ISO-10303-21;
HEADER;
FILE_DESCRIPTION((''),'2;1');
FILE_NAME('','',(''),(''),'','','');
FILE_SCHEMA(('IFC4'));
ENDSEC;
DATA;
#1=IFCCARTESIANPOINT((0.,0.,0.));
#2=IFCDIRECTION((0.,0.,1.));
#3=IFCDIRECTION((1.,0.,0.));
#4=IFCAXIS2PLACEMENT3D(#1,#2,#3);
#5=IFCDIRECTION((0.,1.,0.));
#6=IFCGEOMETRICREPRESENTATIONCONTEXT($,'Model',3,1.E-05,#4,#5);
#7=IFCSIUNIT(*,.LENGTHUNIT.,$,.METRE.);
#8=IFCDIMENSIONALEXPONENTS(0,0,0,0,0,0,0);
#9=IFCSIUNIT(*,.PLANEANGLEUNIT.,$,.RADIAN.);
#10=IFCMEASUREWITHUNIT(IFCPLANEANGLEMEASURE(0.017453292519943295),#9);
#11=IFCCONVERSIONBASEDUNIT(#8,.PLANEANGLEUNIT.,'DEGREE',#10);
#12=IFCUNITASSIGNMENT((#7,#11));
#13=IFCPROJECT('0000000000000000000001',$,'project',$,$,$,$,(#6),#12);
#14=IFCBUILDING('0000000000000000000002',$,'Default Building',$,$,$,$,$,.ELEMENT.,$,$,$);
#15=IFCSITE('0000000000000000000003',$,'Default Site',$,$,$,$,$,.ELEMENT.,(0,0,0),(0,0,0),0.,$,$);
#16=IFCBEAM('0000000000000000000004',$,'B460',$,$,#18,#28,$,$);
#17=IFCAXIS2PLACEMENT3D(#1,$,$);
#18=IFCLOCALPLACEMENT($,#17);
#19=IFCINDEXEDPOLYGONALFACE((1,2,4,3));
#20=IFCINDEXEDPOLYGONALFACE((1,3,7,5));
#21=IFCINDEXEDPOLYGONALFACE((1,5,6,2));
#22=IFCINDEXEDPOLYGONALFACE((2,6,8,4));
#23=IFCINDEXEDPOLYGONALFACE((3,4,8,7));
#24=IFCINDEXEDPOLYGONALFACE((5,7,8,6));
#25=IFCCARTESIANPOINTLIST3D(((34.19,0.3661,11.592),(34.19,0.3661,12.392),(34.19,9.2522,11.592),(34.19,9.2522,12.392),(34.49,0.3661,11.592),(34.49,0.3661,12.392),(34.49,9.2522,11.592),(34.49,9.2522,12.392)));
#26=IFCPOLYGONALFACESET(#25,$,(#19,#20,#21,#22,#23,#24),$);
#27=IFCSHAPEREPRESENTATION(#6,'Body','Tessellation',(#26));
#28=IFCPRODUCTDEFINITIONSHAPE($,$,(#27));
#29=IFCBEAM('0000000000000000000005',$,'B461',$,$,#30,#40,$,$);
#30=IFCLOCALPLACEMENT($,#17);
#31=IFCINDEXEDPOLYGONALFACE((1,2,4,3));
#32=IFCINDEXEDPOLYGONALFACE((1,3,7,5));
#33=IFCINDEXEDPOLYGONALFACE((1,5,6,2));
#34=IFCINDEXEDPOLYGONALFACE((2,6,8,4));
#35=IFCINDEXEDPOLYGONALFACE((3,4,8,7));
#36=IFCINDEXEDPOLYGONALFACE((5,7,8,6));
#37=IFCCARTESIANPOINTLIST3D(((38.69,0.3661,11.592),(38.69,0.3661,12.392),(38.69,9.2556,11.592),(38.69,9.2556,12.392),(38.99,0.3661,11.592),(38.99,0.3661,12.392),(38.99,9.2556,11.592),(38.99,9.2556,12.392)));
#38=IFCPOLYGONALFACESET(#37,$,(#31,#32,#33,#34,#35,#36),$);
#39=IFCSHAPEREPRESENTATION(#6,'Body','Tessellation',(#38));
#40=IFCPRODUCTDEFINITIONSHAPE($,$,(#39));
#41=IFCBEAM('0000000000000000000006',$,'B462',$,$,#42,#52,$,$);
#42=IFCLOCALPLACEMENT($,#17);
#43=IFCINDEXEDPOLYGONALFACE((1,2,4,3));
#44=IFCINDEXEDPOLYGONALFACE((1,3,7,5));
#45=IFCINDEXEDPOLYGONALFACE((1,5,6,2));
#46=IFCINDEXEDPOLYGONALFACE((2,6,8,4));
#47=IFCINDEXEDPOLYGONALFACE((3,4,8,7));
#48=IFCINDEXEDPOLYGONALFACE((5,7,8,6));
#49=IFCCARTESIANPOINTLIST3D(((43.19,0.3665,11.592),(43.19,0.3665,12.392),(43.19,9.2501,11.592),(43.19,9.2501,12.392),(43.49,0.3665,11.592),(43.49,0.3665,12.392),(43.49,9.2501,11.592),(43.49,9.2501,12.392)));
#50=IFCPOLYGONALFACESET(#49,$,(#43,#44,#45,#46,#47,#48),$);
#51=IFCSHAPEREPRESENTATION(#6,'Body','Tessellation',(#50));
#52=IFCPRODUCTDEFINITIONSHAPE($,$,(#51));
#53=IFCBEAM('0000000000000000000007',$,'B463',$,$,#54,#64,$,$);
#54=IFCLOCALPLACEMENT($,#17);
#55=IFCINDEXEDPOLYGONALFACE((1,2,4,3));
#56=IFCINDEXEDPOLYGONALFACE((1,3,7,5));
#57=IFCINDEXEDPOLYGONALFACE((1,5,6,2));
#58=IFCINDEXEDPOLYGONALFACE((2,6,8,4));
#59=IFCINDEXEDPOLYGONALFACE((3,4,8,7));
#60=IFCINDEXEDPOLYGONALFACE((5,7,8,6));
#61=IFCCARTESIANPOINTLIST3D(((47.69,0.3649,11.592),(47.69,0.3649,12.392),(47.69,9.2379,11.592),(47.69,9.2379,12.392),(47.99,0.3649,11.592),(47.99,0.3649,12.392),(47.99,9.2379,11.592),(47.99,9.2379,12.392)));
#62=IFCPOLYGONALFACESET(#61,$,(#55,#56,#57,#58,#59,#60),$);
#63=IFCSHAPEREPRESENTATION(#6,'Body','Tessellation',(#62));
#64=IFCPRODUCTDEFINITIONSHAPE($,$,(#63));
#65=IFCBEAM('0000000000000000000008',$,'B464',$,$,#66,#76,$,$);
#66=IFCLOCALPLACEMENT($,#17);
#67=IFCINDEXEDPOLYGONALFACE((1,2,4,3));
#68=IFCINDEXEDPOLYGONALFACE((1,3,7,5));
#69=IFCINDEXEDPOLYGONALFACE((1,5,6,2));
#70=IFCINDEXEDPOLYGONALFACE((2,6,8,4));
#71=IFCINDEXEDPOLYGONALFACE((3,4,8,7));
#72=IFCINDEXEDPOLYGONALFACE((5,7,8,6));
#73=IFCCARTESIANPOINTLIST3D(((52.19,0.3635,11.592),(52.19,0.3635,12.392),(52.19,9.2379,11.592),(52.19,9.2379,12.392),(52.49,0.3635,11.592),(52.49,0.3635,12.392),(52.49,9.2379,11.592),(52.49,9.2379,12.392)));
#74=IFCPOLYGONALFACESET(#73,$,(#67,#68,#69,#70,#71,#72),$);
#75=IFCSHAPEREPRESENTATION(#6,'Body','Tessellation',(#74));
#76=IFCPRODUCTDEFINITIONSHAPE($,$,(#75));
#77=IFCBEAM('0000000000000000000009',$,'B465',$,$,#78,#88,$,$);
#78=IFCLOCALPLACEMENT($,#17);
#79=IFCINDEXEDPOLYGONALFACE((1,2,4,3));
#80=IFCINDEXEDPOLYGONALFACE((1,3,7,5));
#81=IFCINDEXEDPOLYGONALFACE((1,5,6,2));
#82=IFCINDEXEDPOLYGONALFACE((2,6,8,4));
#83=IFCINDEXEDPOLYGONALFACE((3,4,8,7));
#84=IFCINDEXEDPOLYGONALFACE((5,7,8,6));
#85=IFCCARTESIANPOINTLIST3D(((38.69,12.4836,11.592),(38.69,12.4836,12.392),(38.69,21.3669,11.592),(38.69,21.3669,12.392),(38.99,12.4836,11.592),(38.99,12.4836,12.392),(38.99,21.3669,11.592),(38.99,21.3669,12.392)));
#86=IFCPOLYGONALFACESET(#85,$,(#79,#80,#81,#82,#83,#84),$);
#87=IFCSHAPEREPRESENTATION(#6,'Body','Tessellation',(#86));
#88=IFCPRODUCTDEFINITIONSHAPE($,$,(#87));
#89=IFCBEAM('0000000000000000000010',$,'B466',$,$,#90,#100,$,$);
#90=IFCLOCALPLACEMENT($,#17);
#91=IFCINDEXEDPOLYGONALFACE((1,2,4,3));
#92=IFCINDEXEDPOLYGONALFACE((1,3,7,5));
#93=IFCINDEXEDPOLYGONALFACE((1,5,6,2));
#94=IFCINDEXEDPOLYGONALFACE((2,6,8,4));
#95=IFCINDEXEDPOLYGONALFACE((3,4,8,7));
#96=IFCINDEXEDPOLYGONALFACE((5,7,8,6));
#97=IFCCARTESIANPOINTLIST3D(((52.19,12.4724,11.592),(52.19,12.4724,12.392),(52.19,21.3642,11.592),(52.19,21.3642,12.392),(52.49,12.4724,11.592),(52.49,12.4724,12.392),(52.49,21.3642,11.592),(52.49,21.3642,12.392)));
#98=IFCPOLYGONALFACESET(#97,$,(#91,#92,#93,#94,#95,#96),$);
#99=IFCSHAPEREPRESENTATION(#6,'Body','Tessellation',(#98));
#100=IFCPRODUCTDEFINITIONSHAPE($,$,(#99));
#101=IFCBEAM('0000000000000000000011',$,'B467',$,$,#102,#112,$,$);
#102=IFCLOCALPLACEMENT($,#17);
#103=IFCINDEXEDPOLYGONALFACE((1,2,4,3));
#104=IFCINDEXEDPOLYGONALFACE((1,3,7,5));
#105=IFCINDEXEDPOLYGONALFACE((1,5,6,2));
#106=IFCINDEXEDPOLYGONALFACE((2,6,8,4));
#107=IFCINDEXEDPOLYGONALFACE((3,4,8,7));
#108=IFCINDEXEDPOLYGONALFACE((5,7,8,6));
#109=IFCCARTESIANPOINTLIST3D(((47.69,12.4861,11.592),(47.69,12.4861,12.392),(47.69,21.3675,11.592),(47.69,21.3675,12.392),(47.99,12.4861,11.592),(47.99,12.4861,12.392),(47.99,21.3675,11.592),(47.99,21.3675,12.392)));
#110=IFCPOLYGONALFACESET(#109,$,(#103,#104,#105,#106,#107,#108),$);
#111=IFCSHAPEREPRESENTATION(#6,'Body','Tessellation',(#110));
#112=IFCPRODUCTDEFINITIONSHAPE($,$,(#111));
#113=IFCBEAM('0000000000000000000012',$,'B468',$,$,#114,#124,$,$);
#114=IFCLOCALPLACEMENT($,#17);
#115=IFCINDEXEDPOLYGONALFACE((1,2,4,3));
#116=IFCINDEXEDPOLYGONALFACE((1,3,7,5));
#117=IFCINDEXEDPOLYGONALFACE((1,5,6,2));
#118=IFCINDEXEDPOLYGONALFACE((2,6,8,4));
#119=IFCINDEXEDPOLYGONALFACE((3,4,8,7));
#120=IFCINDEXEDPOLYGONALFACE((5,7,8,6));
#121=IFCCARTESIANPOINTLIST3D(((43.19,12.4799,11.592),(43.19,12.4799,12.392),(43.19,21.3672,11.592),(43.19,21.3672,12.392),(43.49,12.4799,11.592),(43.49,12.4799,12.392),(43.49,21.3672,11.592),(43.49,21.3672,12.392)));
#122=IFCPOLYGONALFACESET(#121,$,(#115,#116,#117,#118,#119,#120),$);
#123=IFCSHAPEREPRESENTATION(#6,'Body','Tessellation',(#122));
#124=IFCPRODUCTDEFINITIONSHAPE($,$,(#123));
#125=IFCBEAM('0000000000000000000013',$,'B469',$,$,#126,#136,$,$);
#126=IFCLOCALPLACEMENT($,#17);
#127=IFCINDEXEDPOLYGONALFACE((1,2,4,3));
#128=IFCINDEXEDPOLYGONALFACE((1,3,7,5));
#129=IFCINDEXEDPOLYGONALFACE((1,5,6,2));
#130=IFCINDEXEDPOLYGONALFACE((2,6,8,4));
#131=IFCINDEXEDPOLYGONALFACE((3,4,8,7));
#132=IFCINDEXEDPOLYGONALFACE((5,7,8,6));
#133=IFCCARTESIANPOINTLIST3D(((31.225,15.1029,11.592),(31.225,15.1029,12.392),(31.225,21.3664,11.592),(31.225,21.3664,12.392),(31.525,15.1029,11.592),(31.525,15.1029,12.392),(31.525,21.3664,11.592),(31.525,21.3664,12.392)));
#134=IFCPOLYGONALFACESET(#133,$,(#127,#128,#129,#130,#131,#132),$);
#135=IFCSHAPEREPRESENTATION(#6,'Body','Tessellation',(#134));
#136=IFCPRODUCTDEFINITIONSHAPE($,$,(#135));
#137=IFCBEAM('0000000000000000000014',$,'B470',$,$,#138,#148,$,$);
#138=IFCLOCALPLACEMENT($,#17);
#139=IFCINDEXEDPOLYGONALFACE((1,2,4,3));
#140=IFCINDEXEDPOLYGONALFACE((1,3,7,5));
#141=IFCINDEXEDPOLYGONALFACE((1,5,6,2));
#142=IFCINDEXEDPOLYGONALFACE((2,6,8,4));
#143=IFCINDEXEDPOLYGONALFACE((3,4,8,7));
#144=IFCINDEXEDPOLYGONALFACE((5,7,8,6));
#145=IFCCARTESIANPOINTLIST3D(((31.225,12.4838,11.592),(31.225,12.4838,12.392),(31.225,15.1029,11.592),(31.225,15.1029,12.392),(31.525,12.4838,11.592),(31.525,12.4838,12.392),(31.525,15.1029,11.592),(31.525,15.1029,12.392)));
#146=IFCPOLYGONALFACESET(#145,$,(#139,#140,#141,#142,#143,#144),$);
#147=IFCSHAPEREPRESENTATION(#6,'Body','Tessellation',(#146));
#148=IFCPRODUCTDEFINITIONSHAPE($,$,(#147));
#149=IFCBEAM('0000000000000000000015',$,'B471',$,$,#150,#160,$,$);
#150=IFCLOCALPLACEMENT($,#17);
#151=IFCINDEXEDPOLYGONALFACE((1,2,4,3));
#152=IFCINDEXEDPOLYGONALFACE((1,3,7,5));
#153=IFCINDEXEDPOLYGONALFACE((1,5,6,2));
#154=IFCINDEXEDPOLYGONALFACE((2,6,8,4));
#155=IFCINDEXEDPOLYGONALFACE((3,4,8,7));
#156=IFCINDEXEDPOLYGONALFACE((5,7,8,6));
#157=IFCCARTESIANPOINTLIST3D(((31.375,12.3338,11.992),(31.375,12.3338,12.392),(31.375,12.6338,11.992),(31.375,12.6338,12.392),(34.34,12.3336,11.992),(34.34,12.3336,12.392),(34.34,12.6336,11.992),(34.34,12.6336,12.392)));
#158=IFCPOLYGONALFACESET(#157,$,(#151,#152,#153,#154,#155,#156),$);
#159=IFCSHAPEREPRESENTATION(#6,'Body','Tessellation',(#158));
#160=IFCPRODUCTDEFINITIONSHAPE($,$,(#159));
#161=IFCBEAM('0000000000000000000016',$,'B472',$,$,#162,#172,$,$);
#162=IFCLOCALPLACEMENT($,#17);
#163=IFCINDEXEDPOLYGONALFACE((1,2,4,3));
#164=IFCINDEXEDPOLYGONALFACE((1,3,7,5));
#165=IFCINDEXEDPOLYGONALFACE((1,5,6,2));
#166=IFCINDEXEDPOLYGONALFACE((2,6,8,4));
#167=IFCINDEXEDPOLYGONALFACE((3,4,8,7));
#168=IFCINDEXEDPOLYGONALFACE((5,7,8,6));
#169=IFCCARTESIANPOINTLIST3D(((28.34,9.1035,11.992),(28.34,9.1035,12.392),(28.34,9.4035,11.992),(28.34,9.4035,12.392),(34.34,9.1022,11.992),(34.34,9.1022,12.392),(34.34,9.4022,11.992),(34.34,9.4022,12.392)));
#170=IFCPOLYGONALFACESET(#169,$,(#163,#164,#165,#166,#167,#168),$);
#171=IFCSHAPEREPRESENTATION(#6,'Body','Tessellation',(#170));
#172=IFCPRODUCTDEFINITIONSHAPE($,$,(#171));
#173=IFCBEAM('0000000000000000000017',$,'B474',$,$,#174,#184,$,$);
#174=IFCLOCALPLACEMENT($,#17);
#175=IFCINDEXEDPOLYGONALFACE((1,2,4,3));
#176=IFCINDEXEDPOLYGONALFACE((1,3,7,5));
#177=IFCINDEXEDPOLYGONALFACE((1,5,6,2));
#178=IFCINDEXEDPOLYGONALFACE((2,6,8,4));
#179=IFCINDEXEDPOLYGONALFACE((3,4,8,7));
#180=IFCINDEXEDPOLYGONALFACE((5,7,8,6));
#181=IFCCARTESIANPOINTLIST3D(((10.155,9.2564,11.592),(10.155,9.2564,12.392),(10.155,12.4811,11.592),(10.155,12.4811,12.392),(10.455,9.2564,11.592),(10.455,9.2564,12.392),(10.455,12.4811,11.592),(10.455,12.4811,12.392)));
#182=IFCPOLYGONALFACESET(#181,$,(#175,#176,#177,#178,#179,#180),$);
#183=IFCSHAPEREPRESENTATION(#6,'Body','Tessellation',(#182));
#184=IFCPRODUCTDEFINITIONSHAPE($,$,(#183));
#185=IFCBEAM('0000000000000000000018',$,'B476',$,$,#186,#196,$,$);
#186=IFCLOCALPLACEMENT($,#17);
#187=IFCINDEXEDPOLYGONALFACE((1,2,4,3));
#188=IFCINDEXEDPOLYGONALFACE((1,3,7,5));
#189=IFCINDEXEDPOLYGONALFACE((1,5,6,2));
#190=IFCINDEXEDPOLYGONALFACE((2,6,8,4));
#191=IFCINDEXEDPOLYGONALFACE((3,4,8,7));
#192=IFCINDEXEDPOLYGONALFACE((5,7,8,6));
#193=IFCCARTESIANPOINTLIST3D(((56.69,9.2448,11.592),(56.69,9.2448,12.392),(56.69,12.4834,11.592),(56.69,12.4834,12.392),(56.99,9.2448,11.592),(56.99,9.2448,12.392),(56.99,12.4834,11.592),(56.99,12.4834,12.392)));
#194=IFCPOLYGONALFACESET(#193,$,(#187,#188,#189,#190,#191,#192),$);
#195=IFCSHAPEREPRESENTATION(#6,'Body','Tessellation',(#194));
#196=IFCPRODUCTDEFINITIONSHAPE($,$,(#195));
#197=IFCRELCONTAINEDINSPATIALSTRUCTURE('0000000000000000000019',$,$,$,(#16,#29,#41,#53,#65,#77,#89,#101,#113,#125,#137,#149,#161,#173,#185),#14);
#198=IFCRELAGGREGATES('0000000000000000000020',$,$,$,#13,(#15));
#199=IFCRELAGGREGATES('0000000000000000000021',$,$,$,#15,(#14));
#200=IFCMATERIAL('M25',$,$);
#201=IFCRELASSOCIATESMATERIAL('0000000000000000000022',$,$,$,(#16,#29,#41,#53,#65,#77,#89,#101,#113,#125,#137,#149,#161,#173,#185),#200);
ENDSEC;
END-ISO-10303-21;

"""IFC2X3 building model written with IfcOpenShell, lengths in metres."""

from ifc_helpers import new_model, entity, si_unit, converted_unit, direction, frame, frame_2d, origin_with_axes, place, context, project, spatial, rectangle, extrude, material, element, save


model = new_model("IFC2X3")

# Units and contexts
model_context = context("Model", 3, precision=1e-05, world=origin_with_axes(), true_north=direction((0.0, 1.0, 0.0)))
ifc_project = project(units=[si_unit("LENGTHUNIT", "METRE"), converted_unit("PLANEANGLEUNIT", "DEGREE", entity("IfcPlaneAngleMeasure", 0.017453292519943295), si_unit("PLANEANGLEUNIT", "RADIAN"), dimensions=[0, 0, 0, 0, 0, 0, 0])], contexts=[model_context])

# Site, building
site = spatial("IfcSite", under=ifc_project, Name="Default Site", CompositionType="ELEMENT", RefLatitude=(0, 0, 0), RefLongitude=(0, 0, 0), RefElevation=0.0)
building = spatial("IfcBuilding", under=site, Name="Default Building", CompositionType="ELEMENT")

# Beams
ifc_material = material(Name="M25")
placement = place(None, origin_with_axes())
element("IfcBeam", 1, at=placement, inside=building, material=ifc_material, Name="B460", context=model_context, shape_type="SweptSolid", body=[
    extrude(rectangle(XDim=0.3, YDim=0.8, at=frame_2d((0.0, 0.0), x_axis=(0.0, 1.0, 0.0))), frame((34.34, 0.3661, 11.992), z_axis=(0.0, 1.0, 0.0), x_axis=(0.0, 0.0, -1.0)), (0.0, 0.0, 1.0), 8.8861),
])
element("IfcBeam", 2, at=placement, inside=building, material=ifc_material, Name="B461", context=model_context, shape_type="SweptSolid", body=[
    extrude(rectangle(XDim=0.3, YDim=0.8, at=frame_2d((0.0, 0.0), x_axis=(0.0, 1.0, 0.0))), frame((38.84, 0.3661, 11.992), z_axis=(0.0, 1.0, 0.0), x_axis=(0.0, 0.0, -1.0)), (0.0, 0.0, 1.0), 8.8895),
])
element("IfcBeam", 3, at=placement, inside=building, material=ifc_material, Name="B462", context=model_context, shape_type="SweptSolid", body=[
    extrude(rectangle(XDim=0.3, YDim=0.8, at=frame_2d((0.0, 0.0), x_axis=(0.0, 1.0, 0.0))), frame((43.34, 0.3665, 11.992), z_axis=(0.0, 1.0, 0.0), x_axis=(0.0, 0.0, -1.0)), (0.0, 0.0, 1.0), 8.8836),
])
element("IfcBeam", 4, at=placement, inside=building, material=ifc_material, Name="B463", context=model_context, shape_type="SweptSolid", body=[
    extrude(rectangle(XDim=0.3, YDim=0.8, at=frame_2d((0.0, 0.0), x_axis=(0.0, 1.0, 0.0))), frame((47.84, 0.3649, 11.992), z_axis=(0.0, 1.0, 0.0), x_axis=(0.0, 0.0, -1.0)), (0.0, 0.0, 1.0), 8.873),
])
element("IfcBeam", 5, at=placement, inside=building, material=ifc_material, Name="B464", context=model_context, shape_type="SweptSolid", body=[
    extrude(rectangle(XDim=0.3, YDim=0.8, at=frame_2d((0.0, 0.0), x_axis=(0.0, 1.0, 0.0))), frame((52.34, 0.3635, 11.992), z_axis=(0.0, 1.0, 0.0), x_axis=(0.0, 0.0, -1.0)), (0.0, 0.0, 1.0), 8.8744),
])
element("IfcBeam", 6, at=placement, inside=building, material=ifc_material, Name="B465", context=model_context, shape_type="SweptSolid", body=[
    extrude(rectangle(XDim=0.3, YDim=0.8, at=frame_2d((0.0, 0.0), x_axis=(0.0, 1.0, 0.0))), frame((38.84, 21.3669, 11.992), z_axis=(0.0, -1.0, 0.0), x_axis=(0.0, 0.0, -1.0)), (0.0, 0.0, 1.0), 8.8833),
])
element("IfcBeam", 7, at=placement, inside=building, material=ifc_material, Name="B466", context=model_context, shape_type="SweptSolid", body=[
    extrude(rectangle(XDim=0.3, YDim=0.8, at=frame_2d((0.0, 0.0), x_axis=(0.0, 1.0, 0.0))), frame((52.34, 12.4724, 11.992), z_axis=(0.0, 1.0, 0.0), x_axis=(0.0, 0.0, -1.0)), (0.0, 0.0, 1.0), 8.8918),
])
element("IfcBeam", 8, at=placement, inside=building, material=ifc_material, Name="B467", context=model_context, shape_type="SweptSolid", body=[
    extrude(rectangle(XDim=0.3, YDim=0.8, at=frame_2d((0.0, 0.0), x_axis=(0.0, 1.0, 0.0))), frame((47.84, 12.4861, 11.992), z_axis=(0.0, 1.0, 0.0), x_axis=(0.0, 0.0, -1.0)), (0.0, 0.0, 1.0), 8.8814),
])
element("IfcBeam", 9, at=placement, inside=building, material=ifc_material, Name="B468", context=model_context, shape_type="SweptSolid", body=[
    extrude(rectangle(XDim=0.3, YDim=0.8, at=frame_2d((0.0, 0.0), x_axis=(0.0, 1.0, 0.0))), frame((43.34, 21.3672, 11.992), z_axis=(0.0, -1.0, 0.0), x_axis=(0.0, 0.0, -1.0)), (0.0, 0.0, 1.0), 8.8873),
])
element("IfcBeam", 10, at=placement, inside=building, material=ifc_material, Name="B469", context=model_context, shape_type="SweptSolid", body=[
    extrude(rectangle(XDim=0.3, YDim=0.8, at=frame_2d((0.0, 0.0), x_axis=(0.0, 1.0, 0.0))), frame((31.375, 21.3664, 11.992), z_axis=(0.0, -1.0, 0.0), x_axis=(0.0, 0.0, -1.0)), (0.0, 0.0, 1.0), 6.2635),
])
element("IfcBeam", 11, at=placement, inside=building, material=ifc_material, Name="B470", context=model_context, shape_type="SweptSolid", body=[
    extrude(rectangle(XDim=0.3, YDim=0.8, at=frame_2d((0.0, 0.0), x_axis=(0.0, 1.0, 0.0))), frame((31.375, 15.1029, 11.992), z_axis=(0.0, -1.0, 0.0), x_axis=(0.0, 0.0, -1.0)), (0.0, 0.0, 1.0), 2.6191),
])
element("IfcBeam", 12, at=placement, inside=building, material=ifc_material, Name="B471", context=model_context, shape_type="SweptSolid", body=[
    extrude(rectangle(XDim=0.3, YDim=0.4, at=frame_2d((0.0, 0.0), x_axis=(0.0, 1.0, 0.0))), frame((31.375, 12.4838, 12.192), z_axis=(1.0, -0.000067, 0.0), x_axis=(0.0, 0.0, -1.0)), (0.0, 0.0, 1.0), 2.965),
])
element("IfcBeam", 13, at=placement, inside=building, material=ifc_material, Name="B472", context=model_context, shape_type="SweptSolid", body=[
    extrude(rectangle(XDim=0.3, YDim=0.4, at=frame_2d((0.0, 0.0), x_axis=(0.0, 1.0, 0.0))), frame((28.34, 9.2535, 12.192), z_axis=(1.0, -0.000213, 0.0), x_axis=(0.0, 0.0, -1.0)), (0.0, 0.0, 1.0), 6.0),
])
element("IfcBeam", 14, at=placement, inside=building, material=ifc_material, Name="B474", context=model_context, shape_type="SweptSolid", body=[
    extrude(rectangle(XDim=0.3, YDim=0.8, at=frame_2d((0.0, 0.0), x_axis=(0.0, 1.0, 0.0))), frame((10.305, 12.4811, 11.992), z_axis=(0.0, -1.0, 0.0), x_axis=(0.0, 0.0, -1.0)), (0.0, 0.0, 1.0), 3.2247),
])
element("IfcBeam", 15, at=placement, inside=building, material=ifc_material, Name="B476", context=model_context, shape_type="SweptSolid", body=[
    extrude(rectangle(XDim=0.3, YDim=0.8, at=frame_2d((0.0, 0.0), x_axis=(0.0, 1.0, 0.0))), frame((56.84, 12.4834, 11.992), z_axis=(0.0, -1.0, 0.0), x_axis=(0.0, 0.0, -1.0)), (0.0, 0.0, 1.0), 3.2386),
])

save(model, "model.ifc")
